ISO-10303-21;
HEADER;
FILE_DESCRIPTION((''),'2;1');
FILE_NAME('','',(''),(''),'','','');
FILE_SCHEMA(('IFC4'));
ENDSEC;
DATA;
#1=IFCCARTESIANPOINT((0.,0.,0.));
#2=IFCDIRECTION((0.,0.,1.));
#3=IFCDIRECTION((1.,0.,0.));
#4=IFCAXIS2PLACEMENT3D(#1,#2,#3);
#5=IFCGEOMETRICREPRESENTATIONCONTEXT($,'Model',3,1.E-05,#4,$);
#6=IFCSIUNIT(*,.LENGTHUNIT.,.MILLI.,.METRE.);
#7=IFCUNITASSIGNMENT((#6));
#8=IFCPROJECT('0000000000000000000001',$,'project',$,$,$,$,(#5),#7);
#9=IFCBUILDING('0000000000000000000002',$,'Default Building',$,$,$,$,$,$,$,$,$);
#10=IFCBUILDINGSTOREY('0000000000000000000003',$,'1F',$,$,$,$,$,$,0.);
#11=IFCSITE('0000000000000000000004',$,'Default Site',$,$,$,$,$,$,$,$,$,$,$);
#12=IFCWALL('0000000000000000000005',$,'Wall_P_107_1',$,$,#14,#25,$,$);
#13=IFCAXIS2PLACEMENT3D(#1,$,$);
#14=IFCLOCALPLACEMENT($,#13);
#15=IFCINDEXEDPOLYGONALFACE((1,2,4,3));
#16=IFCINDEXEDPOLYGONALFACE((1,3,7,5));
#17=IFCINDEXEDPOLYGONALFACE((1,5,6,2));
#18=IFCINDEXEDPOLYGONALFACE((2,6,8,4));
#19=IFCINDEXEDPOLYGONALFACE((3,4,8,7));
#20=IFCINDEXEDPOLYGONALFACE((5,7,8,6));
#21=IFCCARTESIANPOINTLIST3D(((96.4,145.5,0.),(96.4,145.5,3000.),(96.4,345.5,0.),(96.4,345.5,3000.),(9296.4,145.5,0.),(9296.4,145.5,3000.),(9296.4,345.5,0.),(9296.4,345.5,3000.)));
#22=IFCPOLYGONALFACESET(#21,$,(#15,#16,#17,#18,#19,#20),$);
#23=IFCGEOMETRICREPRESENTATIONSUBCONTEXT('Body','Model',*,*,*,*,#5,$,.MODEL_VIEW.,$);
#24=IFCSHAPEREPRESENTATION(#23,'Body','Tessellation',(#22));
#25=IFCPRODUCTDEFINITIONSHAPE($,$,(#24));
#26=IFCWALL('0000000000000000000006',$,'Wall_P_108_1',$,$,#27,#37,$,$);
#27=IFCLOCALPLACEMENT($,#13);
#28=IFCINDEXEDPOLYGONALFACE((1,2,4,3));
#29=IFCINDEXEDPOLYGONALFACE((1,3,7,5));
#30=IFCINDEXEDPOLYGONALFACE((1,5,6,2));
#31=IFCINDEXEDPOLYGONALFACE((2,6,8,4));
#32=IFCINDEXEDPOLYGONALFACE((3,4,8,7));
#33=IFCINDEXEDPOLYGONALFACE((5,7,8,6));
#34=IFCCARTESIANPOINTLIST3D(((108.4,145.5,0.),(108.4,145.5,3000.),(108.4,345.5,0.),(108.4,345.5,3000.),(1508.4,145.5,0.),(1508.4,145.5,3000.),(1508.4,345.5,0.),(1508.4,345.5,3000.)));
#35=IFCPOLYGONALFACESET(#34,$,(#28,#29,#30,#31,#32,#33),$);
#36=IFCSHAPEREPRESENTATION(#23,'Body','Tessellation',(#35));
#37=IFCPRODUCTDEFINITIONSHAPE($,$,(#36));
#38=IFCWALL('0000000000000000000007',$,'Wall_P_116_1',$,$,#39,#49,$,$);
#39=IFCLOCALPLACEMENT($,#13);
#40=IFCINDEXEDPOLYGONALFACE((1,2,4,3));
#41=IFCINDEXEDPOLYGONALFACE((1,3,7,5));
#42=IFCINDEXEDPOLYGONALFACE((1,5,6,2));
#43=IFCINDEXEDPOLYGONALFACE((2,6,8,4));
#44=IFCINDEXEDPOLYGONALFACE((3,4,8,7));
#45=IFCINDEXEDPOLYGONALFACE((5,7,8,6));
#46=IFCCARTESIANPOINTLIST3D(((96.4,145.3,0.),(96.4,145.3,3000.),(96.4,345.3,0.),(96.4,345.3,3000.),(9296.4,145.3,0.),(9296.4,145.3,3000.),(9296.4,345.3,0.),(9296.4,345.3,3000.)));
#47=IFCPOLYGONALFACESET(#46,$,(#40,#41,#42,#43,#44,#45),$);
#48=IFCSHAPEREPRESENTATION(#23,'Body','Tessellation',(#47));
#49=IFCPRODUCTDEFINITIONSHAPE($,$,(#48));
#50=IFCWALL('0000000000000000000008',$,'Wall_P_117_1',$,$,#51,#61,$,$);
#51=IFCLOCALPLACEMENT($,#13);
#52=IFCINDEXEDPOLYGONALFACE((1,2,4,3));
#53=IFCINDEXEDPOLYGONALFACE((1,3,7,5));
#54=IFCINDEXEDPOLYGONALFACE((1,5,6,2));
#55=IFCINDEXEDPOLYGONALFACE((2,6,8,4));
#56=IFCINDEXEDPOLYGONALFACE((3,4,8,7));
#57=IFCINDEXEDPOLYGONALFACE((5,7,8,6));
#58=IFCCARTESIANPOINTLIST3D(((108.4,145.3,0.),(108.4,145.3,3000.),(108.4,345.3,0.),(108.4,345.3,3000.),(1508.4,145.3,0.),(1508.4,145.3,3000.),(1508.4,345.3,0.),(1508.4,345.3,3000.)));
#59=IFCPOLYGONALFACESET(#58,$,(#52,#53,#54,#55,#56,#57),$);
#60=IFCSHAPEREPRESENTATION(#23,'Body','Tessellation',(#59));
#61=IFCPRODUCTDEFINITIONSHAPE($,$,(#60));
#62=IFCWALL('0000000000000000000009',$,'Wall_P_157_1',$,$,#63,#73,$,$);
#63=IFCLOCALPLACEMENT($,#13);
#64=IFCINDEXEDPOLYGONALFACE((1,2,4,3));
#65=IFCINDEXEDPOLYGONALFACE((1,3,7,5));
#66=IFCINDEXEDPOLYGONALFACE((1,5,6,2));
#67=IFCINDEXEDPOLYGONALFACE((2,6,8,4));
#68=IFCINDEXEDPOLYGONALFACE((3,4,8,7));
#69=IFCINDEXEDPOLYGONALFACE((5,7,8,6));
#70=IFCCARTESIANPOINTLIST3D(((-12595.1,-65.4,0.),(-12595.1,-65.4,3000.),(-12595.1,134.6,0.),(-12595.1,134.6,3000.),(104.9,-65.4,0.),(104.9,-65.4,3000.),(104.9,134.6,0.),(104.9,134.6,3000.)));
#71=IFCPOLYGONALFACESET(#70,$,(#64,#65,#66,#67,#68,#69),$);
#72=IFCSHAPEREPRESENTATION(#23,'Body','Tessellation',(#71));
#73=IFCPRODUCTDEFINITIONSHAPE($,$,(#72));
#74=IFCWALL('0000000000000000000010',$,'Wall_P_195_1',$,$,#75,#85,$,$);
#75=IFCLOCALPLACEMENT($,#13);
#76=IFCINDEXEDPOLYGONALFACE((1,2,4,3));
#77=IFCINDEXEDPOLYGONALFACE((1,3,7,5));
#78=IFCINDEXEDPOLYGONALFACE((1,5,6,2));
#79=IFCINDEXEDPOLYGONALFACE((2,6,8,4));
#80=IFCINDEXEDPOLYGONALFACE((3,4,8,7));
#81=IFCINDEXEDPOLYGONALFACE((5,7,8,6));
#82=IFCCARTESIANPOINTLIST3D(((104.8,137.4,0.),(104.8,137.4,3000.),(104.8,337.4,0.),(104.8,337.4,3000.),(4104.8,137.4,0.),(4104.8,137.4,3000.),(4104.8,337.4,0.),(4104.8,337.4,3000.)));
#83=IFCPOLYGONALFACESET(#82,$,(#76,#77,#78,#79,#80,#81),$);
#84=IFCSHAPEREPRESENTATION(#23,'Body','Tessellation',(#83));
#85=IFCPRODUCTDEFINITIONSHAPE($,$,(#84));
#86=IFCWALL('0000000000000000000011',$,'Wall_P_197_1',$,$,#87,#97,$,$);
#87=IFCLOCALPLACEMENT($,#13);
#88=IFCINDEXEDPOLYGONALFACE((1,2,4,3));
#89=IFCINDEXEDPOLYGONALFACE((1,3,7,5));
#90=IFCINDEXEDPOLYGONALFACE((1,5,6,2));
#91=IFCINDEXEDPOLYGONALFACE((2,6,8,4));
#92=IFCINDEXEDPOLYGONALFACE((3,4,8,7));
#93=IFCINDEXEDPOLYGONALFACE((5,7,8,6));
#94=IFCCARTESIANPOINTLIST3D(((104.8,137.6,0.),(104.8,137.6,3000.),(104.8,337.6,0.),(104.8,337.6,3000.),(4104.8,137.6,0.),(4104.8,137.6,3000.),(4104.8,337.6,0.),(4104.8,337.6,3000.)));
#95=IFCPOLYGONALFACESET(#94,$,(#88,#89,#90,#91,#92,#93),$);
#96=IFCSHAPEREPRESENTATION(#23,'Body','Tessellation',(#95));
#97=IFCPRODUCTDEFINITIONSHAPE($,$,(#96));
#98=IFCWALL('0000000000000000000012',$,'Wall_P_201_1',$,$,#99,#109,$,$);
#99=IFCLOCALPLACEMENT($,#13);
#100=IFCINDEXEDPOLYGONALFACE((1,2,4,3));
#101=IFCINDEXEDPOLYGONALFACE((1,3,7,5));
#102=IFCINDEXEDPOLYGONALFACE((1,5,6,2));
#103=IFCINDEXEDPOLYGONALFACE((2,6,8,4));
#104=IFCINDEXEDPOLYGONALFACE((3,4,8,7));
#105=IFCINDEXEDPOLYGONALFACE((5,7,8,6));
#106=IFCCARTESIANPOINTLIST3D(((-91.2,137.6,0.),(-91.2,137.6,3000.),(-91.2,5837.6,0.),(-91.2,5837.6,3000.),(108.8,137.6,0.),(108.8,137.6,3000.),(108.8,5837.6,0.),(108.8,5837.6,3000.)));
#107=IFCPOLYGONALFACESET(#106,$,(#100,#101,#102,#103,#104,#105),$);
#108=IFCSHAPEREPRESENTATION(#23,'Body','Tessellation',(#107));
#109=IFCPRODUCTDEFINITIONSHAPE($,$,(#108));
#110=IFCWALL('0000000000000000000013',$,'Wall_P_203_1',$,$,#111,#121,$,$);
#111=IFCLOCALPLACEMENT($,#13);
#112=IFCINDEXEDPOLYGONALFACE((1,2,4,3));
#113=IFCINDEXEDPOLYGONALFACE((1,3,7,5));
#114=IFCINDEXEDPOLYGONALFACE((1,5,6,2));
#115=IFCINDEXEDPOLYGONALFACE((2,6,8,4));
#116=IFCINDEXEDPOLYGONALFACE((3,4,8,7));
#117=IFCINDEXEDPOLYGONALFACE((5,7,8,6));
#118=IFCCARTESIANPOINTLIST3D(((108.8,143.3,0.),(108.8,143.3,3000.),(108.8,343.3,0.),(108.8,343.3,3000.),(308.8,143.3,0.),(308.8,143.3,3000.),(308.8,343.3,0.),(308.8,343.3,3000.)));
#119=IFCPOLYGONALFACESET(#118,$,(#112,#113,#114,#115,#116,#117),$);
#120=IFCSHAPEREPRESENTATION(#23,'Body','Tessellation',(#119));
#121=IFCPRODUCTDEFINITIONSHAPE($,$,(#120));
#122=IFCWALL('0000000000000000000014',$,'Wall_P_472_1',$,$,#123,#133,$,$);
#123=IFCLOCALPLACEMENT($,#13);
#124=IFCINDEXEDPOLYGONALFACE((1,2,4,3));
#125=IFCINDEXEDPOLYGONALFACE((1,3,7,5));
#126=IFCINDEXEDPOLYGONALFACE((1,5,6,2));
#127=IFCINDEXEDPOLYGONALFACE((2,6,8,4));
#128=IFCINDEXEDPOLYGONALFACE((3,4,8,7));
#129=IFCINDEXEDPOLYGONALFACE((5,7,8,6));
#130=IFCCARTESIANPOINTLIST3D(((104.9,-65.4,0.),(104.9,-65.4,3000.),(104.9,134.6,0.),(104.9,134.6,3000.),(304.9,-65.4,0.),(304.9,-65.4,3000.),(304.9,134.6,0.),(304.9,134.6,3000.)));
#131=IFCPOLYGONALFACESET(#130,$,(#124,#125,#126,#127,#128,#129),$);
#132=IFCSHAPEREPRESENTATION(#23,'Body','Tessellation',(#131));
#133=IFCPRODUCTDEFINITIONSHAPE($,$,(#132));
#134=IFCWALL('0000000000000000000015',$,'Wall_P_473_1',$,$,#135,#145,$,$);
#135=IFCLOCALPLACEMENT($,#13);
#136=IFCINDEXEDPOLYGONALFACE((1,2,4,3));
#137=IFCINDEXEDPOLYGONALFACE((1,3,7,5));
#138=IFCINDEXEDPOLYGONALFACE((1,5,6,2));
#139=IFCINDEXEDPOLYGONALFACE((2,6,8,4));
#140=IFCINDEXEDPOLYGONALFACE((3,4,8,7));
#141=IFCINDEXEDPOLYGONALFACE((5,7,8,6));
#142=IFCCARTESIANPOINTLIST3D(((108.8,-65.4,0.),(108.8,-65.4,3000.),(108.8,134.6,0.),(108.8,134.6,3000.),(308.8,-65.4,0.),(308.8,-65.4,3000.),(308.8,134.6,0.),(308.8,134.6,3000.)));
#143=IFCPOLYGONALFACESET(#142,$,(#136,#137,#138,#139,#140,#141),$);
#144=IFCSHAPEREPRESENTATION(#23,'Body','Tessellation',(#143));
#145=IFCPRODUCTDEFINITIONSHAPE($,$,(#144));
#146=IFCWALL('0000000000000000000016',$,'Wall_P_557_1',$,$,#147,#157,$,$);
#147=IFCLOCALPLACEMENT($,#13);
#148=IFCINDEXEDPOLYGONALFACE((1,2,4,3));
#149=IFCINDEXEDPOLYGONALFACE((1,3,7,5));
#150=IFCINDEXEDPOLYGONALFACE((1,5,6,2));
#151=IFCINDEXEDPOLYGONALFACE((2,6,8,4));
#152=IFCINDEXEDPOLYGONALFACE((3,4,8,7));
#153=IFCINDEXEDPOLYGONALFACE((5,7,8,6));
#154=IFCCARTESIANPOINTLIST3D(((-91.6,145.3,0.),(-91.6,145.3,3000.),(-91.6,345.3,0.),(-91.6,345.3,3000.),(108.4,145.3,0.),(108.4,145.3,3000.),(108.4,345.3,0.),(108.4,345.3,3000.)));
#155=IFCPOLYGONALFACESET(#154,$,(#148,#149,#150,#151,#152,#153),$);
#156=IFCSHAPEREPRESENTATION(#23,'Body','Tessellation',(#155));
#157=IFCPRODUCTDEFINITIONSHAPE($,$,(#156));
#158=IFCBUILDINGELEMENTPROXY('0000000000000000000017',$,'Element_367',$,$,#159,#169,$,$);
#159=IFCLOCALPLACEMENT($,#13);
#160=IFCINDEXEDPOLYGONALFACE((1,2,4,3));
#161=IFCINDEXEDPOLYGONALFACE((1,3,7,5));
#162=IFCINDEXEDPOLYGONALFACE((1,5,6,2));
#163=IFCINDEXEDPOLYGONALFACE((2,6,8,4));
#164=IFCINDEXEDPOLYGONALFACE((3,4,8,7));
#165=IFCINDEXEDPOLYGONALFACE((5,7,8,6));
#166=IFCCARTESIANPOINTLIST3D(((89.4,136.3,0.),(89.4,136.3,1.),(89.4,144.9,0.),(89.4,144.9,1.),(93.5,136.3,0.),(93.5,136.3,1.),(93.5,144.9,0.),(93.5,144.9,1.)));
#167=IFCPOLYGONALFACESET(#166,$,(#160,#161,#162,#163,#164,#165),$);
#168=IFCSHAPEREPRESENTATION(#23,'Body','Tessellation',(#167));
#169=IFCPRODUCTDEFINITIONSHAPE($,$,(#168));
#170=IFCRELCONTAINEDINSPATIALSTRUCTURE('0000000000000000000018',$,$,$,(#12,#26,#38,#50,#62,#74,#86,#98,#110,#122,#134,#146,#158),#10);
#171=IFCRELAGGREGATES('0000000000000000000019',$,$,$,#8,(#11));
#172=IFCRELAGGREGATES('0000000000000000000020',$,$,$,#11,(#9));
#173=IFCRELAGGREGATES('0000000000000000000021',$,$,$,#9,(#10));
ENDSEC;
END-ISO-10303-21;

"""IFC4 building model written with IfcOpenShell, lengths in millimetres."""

from ifc_helpers import new_model, si_unit, frame, origin, origin_with_axes, place, context, subcontext, project, spatial, indexed_curve, rectangle, outline, extrude, element, save


model = new_model("IFC4")

# Units and contexts
model_context = context("Model", 3, precision=1e-05, world=origin_with_axes())
body_context = subcontext(model_context, "Body", "Model", "MODEL_VIEW")
ifc_project = project(units=[si_unit("LENGTHUNIT", "METRE", prefix="MILLI")], contexts=[model_context])

# Site, building, storey
site = spatial("IfcSite", under=ifc_project, Name="Default Site")
building = spatial("IfcBuilding", under=site, Name="Default Building")
storey = spatial("IfcBuildingStorey", under=building, Name="1F", Elevation=0.0)

# Walls
wall_1_placement = place(None, frame((96.4, 145.5, 0.0), z_axis=(0.0, 0.0, 1.0), x_axis=(1.0, 0.0, 0.0)))
element("IfcWall", 1, at=wall_1_placement, inside=storey, Name="Wall_P_107_1", context=body_context, shape_type="SweptSolid", body=[
    extrude(outline(indexed_curve([(0.0, 0.0), (0.0, 200.0), (9200.0, 200.0), (9200.0, 0.0), (0.0, 0.0)], self_intersect=False)), origin_with_axes(), (0.0, 0.0, 1.0), 3000.0),
])
wall_2_placement = place(None, frame((108.4, 145.5, 0.0), z_axis=(0.0, 0.0, 1.0), x_axis=(1.0, 0.0, 0.0)))
element("IfcWall", 2, at=wall_2_placement, inside=storey, Name="Wall_P_108_1", context=body_context, shape_type="SweptSolid", body=[
    extrude(outline(indexed_curve([(0.0, 0.0), (0.0, 200.0), (1400.0, 200.0), (1400.0, 0.0), (0.0, 0.0)], self_intersect=False)), origin_with_axes(), (0.0, 0.0, 1.0), 3000.0),
])
wall_3_placement = place(None, frame((96.4, 145.3, 0.0), z_axis=(0.0, 0.0, 1.0), x_axis=(1.0, 0.0, 0.0)))
element("IfcWall", 3, at=wall_3_placement, inside=storey, Name="Wall_P_116_1", context=body_context, shape_type="SweptSolid", body=[
    extrude(outline(indexed_curve([(0.0, 0.0), (0.0, 200.0), (9200.0, 200.0), (9200.0, 0.0), (0.0, 0.0)], self_intersect=False)), origin_with_axes(), (0.0, 0.0, 1.0), 3000.0),
])
wall_4_placement = place(None, frame((108.4, 145.3, 0.0), z_axis=(0.0, 0.0, 1.0), x_axis=(1.0, 0.0, 0.0)))
element("IfcWall", 4, at=wall_4_placement, inside=storey, Name="Wall_P_117_1", context=body_context, shape_type="SweptSolid", body=[
    extrude(outline(indexed_curve([(0.0, 0.0), (0.0, 200.0), (1400.0, 200.0), (1400.0, 0.0), (0.0, 0.0)], self_intersect=False)), origin_with_axes(), (0.0, 0.0, 1.0), 3000.0),
])
wall_5_placement = place(None, frame((104.9, 134.6, 0.0), z_axis=(0.0, 0.0, 1.0), x_axis=(-1.0, 0.0, 0.0)))
element("IfcWall", 5, at=wall_5_placement, inside=storey, Name="Wall_P_157_1", context=body_context, shape_type="SweptSolid", body=[
    extrude(outline(indexed_curve([(0.0, 0.0), (0.0, 200.0), (12700.0, 200.0), (12700.0, 0.0), (0.0, 0.0)], self_intersect=False)), origin_with_axes(), (0.0, 0.0, 1.0), 3000.0),
])
for number, where, z_axis, x_axis, name in (
    (6, (104.8, 137.4, 0.0), (0.0, 0.0, 1.0), (1.0, 0.0, 0.0), "Wall_P_195_1"),
    (7, (104.8, 137.6, 0.0), (0.0, 0.0, 1.0), (1.0, 0.0, 0.0), "Wall_P_197_1"),
):
    element("IfcWall", number, at=place(None, frame(where, z_axis=z_axis, x_axis=x_axis)), inside=storey, Name=name, context=body_context, shape_type="SweptSolid", body=[
        extrude(outline(indexed_curve([(0.0, 0.0), (0.0, 200.0), (4000.0, 200.0), (4000.0, 0.0), (0.0, 0.0)], self_intersect=False)), origin_with_axes(), (0.0, 0.0, 1.0), 3000.0),
    ])
wall_6_placement = place(None, frame((108.8, 137.6, 0.0), z_axis=(0.0, 0.0, 1.0), x_axis=(0.0, 1.0, 0.0)))
element("IfcWall", 8, at=wall_6_placement, inside=storey, Name="Wall_P_201_1", context=body_context, shape_type="SweptSolid", body=[
    extrude(outline(indexed_curve([(0.0, 0.0), (0.0, 200.0), (5700.0, 200.0), (5700.0, 0.0), (0.0, 0.0)], self_intersect=False)), origin_with_axes(), (0.0, 0.0, 1.0), 3000.0),
])
for number, where, z_axis, x_axis, name in (
    (9, (108.8, 143.3, 0.0), (0.0, 0.0, 1.0), (1.0, 0.0, 0.0), "Wall_P_203_1"),
    (10, (104.9, 134.6, 0.0), (0.0, 0.0, 1.0), (0.0, -1.0, 0.0), "Wall_P_472_1"),
    (11, (108.8, 134.6, 0.0), (0.0, 0.0, 1.0), (0.0, -1.0, 0.0), "Wall_P_473_1"),
    (12, (108.4, 145.3, 0.0), (0.0, 0.0, 1.0), (0.0, 1.0, 0.0), "Wall_P_557_1"),
):
    element("IfcWall", number, at=place(None, frame(where, z_axis=z_axis, x_axis=x_axis)), inside=storey, Name=name, context=body_context, shape_type="SweptSolid", body=[
        extrude(outline(indexed_curve([(0.0, 0.0), (0.0, 200.0), (200.0, 200.0), (200.0, 0.0), (0.0, 0.0)], self_intersect=False)), origin_with_axes(), (0.0, 0.0, 1.0), 3000.0),
    ])

# Building element proxy
proxy_1_placement = place(None, frame((91.5, 140.6, 0.0), z_axis=(0.0, 0.0, 1.0), x_axis=(1.0, 0.0, 0.0)))
element("IfcBuildingElementProxy", 13, at=proxy_1_placement, inside=storey, Name="Element_367", context=body_context, shape_type="SweptSolid", body=[
    extrude(rectangle(XDim=4.1, YDim=8.6), origin(), (0.0, 0.0, 1.0), 1.0),
])

save(model, "model.ifc")
